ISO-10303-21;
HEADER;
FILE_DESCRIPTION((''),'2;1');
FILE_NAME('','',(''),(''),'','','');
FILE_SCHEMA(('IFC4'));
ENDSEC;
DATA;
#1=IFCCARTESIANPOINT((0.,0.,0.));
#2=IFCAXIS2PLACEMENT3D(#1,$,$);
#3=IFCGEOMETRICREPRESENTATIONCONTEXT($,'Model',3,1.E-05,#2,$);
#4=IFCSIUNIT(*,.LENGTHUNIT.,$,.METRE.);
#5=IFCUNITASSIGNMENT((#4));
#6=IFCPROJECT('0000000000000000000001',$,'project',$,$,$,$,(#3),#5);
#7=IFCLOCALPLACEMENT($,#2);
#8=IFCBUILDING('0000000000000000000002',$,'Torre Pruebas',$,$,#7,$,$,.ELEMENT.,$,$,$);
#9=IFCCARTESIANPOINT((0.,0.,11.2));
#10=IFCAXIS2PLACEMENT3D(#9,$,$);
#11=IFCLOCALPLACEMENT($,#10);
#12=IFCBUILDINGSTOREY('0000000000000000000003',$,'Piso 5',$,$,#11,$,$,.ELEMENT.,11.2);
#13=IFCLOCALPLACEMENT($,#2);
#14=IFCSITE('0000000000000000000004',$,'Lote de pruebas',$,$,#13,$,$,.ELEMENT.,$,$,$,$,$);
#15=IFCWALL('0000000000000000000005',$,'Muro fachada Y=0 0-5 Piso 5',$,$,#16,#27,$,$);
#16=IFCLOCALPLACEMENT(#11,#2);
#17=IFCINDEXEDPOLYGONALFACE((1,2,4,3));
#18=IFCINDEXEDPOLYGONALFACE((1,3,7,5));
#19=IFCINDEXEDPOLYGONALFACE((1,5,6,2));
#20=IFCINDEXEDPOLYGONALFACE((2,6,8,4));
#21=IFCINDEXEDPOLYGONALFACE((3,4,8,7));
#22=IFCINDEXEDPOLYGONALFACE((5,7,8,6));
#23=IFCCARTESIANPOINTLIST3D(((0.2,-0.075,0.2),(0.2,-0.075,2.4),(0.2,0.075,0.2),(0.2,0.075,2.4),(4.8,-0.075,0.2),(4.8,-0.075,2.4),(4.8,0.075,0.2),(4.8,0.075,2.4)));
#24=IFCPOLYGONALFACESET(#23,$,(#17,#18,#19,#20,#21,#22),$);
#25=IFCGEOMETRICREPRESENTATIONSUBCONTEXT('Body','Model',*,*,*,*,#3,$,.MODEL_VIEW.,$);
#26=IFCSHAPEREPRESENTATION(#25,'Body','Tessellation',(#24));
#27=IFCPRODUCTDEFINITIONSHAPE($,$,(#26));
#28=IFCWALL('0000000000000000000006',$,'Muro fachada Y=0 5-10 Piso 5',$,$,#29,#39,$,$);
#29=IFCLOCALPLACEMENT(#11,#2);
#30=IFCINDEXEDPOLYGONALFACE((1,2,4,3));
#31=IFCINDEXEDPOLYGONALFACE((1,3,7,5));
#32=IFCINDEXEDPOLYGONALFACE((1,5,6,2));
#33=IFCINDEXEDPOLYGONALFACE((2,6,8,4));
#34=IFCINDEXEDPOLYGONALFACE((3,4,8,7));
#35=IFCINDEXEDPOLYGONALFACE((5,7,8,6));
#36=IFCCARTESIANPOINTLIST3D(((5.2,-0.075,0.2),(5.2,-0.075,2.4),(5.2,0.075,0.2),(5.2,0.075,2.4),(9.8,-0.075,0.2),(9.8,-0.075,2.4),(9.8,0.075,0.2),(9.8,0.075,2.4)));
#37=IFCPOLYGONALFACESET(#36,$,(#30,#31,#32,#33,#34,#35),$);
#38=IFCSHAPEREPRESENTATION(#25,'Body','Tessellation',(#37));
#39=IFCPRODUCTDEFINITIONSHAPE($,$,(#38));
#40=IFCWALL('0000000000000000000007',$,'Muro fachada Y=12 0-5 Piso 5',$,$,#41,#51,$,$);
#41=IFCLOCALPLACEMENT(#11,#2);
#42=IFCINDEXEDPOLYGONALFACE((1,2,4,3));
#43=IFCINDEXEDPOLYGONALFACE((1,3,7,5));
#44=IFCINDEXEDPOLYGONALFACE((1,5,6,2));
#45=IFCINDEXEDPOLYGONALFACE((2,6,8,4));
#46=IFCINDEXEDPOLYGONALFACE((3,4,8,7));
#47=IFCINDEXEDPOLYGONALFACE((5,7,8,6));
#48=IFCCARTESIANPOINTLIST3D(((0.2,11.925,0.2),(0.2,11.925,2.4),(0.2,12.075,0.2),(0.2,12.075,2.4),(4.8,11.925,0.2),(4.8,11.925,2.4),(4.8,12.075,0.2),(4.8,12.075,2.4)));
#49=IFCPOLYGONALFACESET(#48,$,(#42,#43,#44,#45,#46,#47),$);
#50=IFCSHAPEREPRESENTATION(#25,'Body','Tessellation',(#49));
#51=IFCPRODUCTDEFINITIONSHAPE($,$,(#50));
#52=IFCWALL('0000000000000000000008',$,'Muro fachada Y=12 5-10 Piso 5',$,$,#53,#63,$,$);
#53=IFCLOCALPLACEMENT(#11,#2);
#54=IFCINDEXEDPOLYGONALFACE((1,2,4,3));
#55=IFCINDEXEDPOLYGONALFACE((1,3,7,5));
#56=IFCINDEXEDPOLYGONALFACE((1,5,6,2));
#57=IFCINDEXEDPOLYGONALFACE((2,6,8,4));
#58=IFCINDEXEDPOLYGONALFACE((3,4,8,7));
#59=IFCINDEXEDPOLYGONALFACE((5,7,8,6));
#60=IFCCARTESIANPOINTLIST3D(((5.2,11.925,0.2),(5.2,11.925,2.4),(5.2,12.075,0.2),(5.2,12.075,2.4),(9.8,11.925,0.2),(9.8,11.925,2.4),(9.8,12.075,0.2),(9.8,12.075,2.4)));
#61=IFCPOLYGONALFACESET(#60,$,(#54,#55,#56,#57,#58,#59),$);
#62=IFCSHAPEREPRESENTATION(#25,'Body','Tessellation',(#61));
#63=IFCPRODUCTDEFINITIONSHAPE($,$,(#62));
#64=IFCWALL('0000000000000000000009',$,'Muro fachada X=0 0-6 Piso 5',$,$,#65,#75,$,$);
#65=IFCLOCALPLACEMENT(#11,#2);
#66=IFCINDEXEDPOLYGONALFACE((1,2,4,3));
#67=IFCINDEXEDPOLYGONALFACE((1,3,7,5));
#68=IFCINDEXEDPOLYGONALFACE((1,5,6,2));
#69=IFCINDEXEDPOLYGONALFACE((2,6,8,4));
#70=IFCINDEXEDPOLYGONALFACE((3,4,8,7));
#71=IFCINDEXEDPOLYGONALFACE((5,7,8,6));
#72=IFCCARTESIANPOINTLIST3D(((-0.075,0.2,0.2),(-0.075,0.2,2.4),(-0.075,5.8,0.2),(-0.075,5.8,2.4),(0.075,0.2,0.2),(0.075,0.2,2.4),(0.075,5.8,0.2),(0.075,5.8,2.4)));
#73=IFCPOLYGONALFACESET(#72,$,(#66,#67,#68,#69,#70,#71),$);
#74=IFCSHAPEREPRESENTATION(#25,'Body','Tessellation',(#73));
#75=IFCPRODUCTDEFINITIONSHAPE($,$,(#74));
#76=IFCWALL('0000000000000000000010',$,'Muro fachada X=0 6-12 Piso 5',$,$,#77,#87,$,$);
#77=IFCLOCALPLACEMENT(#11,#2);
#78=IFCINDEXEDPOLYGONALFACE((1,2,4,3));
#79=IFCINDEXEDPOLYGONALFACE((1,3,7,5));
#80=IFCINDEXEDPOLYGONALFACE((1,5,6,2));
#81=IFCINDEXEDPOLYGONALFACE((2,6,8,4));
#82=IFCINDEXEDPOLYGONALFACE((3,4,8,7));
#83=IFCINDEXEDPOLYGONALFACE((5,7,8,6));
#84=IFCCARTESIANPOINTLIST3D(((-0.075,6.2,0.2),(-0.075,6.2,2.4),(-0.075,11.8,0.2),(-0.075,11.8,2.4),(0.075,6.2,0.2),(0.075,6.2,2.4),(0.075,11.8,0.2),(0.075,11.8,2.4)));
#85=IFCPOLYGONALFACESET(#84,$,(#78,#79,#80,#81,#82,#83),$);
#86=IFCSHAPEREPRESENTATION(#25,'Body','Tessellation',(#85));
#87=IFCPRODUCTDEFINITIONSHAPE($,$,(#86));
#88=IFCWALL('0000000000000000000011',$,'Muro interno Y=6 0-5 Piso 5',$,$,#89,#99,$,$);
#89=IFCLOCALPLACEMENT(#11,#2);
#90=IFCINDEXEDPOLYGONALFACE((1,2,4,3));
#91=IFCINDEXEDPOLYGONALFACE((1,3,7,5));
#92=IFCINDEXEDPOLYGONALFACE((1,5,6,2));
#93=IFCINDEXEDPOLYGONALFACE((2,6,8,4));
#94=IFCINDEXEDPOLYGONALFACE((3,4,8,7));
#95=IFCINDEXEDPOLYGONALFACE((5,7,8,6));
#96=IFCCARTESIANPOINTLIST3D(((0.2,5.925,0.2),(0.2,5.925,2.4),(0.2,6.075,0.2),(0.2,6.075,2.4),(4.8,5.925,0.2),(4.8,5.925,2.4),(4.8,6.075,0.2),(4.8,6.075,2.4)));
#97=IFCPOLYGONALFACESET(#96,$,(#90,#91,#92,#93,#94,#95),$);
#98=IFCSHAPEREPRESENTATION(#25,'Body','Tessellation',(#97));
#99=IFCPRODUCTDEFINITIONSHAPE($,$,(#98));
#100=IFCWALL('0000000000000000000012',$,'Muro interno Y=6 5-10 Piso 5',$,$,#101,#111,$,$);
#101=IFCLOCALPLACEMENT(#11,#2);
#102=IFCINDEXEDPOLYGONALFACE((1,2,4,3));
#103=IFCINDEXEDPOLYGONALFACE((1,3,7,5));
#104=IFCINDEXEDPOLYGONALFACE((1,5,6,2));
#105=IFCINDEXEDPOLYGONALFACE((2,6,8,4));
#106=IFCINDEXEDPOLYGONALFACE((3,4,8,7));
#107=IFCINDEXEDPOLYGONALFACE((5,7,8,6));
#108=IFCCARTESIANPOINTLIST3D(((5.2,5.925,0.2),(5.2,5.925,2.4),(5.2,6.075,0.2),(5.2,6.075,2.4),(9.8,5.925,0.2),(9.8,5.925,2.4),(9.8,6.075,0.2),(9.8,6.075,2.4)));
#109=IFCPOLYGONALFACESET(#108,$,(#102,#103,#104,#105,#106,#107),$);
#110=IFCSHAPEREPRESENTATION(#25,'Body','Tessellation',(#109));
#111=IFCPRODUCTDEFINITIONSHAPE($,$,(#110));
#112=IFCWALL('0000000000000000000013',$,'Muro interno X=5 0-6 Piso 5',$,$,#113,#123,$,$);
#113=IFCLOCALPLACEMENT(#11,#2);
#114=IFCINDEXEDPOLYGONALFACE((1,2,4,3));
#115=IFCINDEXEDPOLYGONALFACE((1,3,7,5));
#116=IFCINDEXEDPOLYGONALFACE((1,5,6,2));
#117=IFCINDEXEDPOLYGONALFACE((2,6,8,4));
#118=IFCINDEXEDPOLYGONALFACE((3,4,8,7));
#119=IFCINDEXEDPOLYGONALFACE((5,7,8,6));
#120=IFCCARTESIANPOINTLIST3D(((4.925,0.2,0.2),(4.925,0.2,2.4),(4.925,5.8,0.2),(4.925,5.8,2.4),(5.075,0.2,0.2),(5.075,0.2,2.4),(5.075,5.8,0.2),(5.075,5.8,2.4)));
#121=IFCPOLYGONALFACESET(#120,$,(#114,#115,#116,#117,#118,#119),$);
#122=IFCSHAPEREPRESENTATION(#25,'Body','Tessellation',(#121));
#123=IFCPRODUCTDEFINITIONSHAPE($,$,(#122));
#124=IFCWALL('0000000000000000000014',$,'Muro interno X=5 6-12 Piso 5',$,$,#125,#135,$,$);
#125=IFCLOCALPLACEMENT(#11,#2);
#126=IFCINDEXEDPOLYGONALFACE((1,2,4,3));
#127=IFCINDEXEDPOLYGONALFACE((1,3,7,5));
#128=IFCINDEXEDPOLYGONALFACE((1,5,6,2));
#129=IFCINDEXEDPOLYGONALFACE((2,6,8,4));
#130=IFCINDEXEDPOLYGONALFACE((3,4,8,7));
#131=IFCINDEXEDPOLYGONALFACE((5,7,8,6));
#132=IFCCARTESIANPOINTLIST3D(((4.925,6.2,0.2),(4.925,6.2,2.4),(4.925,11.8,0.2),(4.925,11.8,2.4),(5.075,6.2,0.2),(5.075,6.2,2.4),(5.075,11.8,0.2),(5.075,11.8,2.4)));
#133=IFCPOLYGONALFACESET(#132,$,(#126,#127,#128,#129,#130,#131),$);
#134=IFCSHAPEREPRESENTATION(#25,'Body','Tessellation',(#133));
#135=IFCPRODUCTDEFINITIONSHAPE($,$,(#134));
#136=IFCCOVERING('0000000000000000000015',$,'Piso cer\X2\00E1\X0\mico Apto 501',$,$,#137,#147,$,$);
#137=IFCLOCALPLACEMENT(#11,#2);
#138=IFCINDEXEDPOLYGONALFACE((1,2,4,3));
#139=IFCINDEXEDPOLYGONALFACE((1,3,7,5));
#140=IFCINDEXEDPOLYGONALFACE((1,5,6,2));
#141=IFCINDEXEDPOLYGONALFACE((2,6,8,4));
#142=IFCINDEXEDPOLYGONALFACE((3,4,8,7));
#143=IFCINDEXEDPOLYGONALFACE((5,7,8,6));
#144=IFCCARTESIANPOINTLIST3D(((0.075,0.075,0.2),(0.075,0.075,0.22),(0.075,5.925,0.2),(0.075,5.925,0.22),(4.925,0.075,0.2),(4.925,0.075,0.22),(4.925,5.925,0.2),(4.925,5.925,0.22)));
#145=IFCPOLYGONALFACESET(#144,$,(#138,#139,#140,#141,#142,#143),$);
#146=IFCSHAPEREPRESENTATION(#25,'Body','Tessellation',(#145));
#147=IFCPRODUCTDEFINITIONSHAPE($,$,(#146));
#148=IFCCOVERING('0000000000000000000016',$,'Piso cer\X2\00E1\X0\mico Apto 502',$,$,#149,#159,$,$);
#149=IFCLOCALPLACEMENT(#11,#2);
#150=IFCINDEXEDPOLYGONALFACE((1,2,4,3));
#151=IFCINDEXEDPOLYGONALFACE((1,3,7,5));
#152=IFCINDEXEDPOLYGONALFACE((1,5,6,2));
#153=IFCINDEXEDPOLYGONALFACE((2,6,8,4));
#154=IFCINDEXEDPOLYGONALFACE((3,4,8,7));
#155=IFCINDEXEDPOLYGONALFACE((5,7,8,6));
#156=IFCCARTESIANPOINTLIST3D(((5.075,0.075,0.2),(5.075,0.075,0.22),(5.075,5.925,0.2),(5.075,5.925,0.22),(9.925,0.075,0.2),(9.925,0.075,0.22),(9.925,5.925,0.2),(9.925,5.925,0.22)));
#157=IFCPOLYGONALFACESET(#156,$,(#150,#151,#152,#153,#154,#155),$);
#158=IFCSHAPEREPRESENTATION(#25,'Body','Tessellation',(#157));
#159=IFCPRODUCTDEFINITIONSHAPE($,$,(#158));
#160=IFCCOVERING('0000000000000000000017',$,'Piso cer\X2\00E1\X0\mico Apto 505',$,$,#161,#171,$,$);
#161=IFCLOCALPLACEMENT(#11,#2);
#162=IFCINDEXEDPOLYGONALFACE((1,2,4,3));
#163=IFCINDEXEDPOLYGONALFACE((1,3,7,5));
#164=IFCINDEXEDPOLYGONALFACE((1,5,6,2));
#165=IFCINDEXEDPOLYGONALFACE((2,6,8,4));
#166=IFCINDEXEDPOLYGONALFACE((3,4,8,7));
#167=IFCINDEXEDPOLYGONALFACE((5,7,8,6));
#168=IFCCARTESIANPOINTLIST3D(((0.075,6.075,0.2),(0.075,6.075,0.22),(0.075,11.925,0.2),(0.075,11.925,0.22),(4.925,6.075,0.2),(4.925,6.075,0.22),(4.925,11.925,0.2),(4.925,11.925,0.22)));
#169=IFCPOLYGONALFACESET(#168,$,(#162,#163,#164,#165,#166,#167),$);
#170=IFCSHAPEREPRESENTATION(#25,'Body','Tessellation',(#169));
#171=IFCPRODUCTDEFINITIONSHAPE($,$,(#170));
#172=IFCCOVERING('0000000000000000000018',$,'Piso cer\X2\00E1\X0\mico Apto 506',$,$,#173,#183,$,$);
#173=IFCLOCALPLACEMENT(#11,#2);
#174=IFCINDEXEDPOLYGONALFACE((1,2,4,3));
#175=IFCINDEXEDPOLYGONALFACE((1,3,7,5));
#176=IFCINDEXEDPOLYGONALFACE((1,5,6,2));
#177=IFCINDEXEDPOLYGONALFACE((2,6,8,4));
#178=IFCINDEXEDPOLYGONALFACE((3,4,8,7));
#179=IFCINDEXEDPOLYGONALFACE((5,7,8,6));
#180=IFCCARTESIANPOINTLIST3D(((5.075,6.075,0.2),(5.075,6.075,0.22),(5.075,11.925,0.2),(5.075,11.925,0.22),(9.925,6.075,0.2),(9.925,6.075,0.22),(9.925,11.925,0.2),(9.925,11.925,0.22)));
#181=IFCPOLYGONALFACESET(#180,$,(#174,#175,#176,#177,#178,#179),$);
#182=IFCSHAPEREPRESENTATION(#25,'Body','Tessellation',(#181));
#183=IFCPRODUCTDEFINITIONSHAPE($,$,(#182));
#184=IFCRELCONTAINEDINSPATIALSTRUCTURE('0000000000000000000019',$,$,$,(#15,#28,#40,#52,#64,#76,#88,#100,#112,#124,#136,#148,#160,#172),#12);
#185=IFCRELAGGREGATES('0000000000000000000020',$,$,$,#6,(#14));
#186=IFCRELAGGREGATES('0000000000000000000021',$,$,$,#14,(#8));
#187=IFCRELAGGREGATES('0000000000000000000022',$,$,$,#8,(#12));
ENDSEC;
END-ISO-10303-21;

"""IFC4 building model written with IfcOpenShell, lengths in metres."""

from ifc_helpers import new_model, si_unit, frame, origin, origin_2d, place, context, subcontext, project, spatial, rectangle, extrude, element, save


model = new_model("IFC4")

# Units and contexts
model_context = context("Model", 3, precision=1e-05, world=origin())
body_context = subcontext(model_context, "Body", "Model", "MODEL_VIEW")
ifc_project = project(units=[si_unit("LENGTHUNIT", "METRE")], contexts=[model_context])

# Site, building, storey
site_placement = place(None, origin())
site = spatial("IfcSite", under=ifc_project, at=site_placement, Name="Lote de pruebas", CompositionType="ELEMENT")
building_placement = place(None, origin())
building = spatial("IfcBuilding", under=site, at=building_placement, Name="Torre Pruebas", CompositionType="ELEMENT")
storey_placement = place(None, frame((0.0, 0.0, 11.2)))
storey = spatial("IfcBuildingStorey", under=building, at=storey_placement, Name="Piso 5", CompositionType="ELEMENT", Elevation=11.2)

# Walls
for number, where, name in (
    (1, (2.5, 0.0, 11.4), "Muro fachada Y=0 0-5 Piso 5"),
    (2, (7.5, 0.0, 11.4), "Muro fachada Y=0 5-10 Piso 5"),
    (3, (2.5, 12.0, 11.4), "Muro fachada Y=12 0-5 Piso 5"),
    (4, (7.5, 12.0, 11.4), "Muro fachada Y=12 5-10 Piso 5"),
):
    element("IfcWall", number, at=place(None, frame(where)), inside=storey, Name=name, context=body_context, shape_type="SweptSolid", body=[
        extrude(rectangle(XDim=4.6, YDim=0.15, at=origin_2d()), origin(), (0.0, 0.0, 1.0), 2.2),
    ])
for number, where, name in (
    (5, (0.0, 3.0, 11.4), "Muro fachada X=0 0-6 Piso 5"),
    (6, (0.0, 9.0, 11.4), "Muro fachada X=0 6-12 Piso 5"),
):
    element("IfcWall", number, at=place(None, frame(where)), inside=storey, Name=name, context=body_context, shape_type="SweptSolid", body=[
        extrude(rectangle(XDim=0.15, YDim=5.6, at=origin_2d()), origin(), (0.0, 0.0, 1.0), 2.2),
    ])
for number, where, name in (
    (7, (2.5, 6.0, 11.4), "Muro interno Y=6 0-5 Piso 5"),
    (8, (7.5, 6.0, 11.4), "Muro interno Y=6 5-10 Piso 5"),
):
    element("IfcWall", number, at=place(None, frame(where)), inside=storey, Name=name, context=body_context, shape_type="SweptSolid", body=[
        extrude(rectangle(XDim=4.6, YDim=0.15, at=origin_2d()), origin(), (0.0, 0.0, 1.0), 2.2),
    ])
for number, where, name in (
    (9, (5.0, 3.0, 11.4), "Muro interno X=5 0-6 Piso 5"),
    (10, (5.0, 9.0, 11.4), "Muro interno X=5 6-12 Piso 5"),
):
    element("IfcWall", number, at=place(None, frame(where)), inside=storey, Name=name, context=body_context, shape_type="SweptSolid", body=[
        extrude(rectangle(XDim=0.15, YDim=5.6, at=origin_2d()), origin(), (0.0, 0.0, 1.0), 2.2),
    ])

# Coverings
for number, where, name in (
    (11, (2.5, 3.0, 11.4), "Piso cerámico Apto 501"),
    (12, (7.5, 3.0, 11.4), "Piso cerámico Apto 502"),
    (13, (2.5, 9.0, 11.4), "Piso cerámico Apto 505"),
    (14, (7.5, 9.0, 11.4), "Piso cerámico Apto 506"),
):
    element("IfcCovering", number, at=place(None, frame(where)), inside=storey, Name=name, context=body_context, shape_type="SweptSolid", body=[
        extrude(rectangle(XDim=4.85, YDim=5.85, at=origin_2d()), origin(), (0.0, 0.0, 1.0), 0.02),
    ])

save(model, "model.ifc")
